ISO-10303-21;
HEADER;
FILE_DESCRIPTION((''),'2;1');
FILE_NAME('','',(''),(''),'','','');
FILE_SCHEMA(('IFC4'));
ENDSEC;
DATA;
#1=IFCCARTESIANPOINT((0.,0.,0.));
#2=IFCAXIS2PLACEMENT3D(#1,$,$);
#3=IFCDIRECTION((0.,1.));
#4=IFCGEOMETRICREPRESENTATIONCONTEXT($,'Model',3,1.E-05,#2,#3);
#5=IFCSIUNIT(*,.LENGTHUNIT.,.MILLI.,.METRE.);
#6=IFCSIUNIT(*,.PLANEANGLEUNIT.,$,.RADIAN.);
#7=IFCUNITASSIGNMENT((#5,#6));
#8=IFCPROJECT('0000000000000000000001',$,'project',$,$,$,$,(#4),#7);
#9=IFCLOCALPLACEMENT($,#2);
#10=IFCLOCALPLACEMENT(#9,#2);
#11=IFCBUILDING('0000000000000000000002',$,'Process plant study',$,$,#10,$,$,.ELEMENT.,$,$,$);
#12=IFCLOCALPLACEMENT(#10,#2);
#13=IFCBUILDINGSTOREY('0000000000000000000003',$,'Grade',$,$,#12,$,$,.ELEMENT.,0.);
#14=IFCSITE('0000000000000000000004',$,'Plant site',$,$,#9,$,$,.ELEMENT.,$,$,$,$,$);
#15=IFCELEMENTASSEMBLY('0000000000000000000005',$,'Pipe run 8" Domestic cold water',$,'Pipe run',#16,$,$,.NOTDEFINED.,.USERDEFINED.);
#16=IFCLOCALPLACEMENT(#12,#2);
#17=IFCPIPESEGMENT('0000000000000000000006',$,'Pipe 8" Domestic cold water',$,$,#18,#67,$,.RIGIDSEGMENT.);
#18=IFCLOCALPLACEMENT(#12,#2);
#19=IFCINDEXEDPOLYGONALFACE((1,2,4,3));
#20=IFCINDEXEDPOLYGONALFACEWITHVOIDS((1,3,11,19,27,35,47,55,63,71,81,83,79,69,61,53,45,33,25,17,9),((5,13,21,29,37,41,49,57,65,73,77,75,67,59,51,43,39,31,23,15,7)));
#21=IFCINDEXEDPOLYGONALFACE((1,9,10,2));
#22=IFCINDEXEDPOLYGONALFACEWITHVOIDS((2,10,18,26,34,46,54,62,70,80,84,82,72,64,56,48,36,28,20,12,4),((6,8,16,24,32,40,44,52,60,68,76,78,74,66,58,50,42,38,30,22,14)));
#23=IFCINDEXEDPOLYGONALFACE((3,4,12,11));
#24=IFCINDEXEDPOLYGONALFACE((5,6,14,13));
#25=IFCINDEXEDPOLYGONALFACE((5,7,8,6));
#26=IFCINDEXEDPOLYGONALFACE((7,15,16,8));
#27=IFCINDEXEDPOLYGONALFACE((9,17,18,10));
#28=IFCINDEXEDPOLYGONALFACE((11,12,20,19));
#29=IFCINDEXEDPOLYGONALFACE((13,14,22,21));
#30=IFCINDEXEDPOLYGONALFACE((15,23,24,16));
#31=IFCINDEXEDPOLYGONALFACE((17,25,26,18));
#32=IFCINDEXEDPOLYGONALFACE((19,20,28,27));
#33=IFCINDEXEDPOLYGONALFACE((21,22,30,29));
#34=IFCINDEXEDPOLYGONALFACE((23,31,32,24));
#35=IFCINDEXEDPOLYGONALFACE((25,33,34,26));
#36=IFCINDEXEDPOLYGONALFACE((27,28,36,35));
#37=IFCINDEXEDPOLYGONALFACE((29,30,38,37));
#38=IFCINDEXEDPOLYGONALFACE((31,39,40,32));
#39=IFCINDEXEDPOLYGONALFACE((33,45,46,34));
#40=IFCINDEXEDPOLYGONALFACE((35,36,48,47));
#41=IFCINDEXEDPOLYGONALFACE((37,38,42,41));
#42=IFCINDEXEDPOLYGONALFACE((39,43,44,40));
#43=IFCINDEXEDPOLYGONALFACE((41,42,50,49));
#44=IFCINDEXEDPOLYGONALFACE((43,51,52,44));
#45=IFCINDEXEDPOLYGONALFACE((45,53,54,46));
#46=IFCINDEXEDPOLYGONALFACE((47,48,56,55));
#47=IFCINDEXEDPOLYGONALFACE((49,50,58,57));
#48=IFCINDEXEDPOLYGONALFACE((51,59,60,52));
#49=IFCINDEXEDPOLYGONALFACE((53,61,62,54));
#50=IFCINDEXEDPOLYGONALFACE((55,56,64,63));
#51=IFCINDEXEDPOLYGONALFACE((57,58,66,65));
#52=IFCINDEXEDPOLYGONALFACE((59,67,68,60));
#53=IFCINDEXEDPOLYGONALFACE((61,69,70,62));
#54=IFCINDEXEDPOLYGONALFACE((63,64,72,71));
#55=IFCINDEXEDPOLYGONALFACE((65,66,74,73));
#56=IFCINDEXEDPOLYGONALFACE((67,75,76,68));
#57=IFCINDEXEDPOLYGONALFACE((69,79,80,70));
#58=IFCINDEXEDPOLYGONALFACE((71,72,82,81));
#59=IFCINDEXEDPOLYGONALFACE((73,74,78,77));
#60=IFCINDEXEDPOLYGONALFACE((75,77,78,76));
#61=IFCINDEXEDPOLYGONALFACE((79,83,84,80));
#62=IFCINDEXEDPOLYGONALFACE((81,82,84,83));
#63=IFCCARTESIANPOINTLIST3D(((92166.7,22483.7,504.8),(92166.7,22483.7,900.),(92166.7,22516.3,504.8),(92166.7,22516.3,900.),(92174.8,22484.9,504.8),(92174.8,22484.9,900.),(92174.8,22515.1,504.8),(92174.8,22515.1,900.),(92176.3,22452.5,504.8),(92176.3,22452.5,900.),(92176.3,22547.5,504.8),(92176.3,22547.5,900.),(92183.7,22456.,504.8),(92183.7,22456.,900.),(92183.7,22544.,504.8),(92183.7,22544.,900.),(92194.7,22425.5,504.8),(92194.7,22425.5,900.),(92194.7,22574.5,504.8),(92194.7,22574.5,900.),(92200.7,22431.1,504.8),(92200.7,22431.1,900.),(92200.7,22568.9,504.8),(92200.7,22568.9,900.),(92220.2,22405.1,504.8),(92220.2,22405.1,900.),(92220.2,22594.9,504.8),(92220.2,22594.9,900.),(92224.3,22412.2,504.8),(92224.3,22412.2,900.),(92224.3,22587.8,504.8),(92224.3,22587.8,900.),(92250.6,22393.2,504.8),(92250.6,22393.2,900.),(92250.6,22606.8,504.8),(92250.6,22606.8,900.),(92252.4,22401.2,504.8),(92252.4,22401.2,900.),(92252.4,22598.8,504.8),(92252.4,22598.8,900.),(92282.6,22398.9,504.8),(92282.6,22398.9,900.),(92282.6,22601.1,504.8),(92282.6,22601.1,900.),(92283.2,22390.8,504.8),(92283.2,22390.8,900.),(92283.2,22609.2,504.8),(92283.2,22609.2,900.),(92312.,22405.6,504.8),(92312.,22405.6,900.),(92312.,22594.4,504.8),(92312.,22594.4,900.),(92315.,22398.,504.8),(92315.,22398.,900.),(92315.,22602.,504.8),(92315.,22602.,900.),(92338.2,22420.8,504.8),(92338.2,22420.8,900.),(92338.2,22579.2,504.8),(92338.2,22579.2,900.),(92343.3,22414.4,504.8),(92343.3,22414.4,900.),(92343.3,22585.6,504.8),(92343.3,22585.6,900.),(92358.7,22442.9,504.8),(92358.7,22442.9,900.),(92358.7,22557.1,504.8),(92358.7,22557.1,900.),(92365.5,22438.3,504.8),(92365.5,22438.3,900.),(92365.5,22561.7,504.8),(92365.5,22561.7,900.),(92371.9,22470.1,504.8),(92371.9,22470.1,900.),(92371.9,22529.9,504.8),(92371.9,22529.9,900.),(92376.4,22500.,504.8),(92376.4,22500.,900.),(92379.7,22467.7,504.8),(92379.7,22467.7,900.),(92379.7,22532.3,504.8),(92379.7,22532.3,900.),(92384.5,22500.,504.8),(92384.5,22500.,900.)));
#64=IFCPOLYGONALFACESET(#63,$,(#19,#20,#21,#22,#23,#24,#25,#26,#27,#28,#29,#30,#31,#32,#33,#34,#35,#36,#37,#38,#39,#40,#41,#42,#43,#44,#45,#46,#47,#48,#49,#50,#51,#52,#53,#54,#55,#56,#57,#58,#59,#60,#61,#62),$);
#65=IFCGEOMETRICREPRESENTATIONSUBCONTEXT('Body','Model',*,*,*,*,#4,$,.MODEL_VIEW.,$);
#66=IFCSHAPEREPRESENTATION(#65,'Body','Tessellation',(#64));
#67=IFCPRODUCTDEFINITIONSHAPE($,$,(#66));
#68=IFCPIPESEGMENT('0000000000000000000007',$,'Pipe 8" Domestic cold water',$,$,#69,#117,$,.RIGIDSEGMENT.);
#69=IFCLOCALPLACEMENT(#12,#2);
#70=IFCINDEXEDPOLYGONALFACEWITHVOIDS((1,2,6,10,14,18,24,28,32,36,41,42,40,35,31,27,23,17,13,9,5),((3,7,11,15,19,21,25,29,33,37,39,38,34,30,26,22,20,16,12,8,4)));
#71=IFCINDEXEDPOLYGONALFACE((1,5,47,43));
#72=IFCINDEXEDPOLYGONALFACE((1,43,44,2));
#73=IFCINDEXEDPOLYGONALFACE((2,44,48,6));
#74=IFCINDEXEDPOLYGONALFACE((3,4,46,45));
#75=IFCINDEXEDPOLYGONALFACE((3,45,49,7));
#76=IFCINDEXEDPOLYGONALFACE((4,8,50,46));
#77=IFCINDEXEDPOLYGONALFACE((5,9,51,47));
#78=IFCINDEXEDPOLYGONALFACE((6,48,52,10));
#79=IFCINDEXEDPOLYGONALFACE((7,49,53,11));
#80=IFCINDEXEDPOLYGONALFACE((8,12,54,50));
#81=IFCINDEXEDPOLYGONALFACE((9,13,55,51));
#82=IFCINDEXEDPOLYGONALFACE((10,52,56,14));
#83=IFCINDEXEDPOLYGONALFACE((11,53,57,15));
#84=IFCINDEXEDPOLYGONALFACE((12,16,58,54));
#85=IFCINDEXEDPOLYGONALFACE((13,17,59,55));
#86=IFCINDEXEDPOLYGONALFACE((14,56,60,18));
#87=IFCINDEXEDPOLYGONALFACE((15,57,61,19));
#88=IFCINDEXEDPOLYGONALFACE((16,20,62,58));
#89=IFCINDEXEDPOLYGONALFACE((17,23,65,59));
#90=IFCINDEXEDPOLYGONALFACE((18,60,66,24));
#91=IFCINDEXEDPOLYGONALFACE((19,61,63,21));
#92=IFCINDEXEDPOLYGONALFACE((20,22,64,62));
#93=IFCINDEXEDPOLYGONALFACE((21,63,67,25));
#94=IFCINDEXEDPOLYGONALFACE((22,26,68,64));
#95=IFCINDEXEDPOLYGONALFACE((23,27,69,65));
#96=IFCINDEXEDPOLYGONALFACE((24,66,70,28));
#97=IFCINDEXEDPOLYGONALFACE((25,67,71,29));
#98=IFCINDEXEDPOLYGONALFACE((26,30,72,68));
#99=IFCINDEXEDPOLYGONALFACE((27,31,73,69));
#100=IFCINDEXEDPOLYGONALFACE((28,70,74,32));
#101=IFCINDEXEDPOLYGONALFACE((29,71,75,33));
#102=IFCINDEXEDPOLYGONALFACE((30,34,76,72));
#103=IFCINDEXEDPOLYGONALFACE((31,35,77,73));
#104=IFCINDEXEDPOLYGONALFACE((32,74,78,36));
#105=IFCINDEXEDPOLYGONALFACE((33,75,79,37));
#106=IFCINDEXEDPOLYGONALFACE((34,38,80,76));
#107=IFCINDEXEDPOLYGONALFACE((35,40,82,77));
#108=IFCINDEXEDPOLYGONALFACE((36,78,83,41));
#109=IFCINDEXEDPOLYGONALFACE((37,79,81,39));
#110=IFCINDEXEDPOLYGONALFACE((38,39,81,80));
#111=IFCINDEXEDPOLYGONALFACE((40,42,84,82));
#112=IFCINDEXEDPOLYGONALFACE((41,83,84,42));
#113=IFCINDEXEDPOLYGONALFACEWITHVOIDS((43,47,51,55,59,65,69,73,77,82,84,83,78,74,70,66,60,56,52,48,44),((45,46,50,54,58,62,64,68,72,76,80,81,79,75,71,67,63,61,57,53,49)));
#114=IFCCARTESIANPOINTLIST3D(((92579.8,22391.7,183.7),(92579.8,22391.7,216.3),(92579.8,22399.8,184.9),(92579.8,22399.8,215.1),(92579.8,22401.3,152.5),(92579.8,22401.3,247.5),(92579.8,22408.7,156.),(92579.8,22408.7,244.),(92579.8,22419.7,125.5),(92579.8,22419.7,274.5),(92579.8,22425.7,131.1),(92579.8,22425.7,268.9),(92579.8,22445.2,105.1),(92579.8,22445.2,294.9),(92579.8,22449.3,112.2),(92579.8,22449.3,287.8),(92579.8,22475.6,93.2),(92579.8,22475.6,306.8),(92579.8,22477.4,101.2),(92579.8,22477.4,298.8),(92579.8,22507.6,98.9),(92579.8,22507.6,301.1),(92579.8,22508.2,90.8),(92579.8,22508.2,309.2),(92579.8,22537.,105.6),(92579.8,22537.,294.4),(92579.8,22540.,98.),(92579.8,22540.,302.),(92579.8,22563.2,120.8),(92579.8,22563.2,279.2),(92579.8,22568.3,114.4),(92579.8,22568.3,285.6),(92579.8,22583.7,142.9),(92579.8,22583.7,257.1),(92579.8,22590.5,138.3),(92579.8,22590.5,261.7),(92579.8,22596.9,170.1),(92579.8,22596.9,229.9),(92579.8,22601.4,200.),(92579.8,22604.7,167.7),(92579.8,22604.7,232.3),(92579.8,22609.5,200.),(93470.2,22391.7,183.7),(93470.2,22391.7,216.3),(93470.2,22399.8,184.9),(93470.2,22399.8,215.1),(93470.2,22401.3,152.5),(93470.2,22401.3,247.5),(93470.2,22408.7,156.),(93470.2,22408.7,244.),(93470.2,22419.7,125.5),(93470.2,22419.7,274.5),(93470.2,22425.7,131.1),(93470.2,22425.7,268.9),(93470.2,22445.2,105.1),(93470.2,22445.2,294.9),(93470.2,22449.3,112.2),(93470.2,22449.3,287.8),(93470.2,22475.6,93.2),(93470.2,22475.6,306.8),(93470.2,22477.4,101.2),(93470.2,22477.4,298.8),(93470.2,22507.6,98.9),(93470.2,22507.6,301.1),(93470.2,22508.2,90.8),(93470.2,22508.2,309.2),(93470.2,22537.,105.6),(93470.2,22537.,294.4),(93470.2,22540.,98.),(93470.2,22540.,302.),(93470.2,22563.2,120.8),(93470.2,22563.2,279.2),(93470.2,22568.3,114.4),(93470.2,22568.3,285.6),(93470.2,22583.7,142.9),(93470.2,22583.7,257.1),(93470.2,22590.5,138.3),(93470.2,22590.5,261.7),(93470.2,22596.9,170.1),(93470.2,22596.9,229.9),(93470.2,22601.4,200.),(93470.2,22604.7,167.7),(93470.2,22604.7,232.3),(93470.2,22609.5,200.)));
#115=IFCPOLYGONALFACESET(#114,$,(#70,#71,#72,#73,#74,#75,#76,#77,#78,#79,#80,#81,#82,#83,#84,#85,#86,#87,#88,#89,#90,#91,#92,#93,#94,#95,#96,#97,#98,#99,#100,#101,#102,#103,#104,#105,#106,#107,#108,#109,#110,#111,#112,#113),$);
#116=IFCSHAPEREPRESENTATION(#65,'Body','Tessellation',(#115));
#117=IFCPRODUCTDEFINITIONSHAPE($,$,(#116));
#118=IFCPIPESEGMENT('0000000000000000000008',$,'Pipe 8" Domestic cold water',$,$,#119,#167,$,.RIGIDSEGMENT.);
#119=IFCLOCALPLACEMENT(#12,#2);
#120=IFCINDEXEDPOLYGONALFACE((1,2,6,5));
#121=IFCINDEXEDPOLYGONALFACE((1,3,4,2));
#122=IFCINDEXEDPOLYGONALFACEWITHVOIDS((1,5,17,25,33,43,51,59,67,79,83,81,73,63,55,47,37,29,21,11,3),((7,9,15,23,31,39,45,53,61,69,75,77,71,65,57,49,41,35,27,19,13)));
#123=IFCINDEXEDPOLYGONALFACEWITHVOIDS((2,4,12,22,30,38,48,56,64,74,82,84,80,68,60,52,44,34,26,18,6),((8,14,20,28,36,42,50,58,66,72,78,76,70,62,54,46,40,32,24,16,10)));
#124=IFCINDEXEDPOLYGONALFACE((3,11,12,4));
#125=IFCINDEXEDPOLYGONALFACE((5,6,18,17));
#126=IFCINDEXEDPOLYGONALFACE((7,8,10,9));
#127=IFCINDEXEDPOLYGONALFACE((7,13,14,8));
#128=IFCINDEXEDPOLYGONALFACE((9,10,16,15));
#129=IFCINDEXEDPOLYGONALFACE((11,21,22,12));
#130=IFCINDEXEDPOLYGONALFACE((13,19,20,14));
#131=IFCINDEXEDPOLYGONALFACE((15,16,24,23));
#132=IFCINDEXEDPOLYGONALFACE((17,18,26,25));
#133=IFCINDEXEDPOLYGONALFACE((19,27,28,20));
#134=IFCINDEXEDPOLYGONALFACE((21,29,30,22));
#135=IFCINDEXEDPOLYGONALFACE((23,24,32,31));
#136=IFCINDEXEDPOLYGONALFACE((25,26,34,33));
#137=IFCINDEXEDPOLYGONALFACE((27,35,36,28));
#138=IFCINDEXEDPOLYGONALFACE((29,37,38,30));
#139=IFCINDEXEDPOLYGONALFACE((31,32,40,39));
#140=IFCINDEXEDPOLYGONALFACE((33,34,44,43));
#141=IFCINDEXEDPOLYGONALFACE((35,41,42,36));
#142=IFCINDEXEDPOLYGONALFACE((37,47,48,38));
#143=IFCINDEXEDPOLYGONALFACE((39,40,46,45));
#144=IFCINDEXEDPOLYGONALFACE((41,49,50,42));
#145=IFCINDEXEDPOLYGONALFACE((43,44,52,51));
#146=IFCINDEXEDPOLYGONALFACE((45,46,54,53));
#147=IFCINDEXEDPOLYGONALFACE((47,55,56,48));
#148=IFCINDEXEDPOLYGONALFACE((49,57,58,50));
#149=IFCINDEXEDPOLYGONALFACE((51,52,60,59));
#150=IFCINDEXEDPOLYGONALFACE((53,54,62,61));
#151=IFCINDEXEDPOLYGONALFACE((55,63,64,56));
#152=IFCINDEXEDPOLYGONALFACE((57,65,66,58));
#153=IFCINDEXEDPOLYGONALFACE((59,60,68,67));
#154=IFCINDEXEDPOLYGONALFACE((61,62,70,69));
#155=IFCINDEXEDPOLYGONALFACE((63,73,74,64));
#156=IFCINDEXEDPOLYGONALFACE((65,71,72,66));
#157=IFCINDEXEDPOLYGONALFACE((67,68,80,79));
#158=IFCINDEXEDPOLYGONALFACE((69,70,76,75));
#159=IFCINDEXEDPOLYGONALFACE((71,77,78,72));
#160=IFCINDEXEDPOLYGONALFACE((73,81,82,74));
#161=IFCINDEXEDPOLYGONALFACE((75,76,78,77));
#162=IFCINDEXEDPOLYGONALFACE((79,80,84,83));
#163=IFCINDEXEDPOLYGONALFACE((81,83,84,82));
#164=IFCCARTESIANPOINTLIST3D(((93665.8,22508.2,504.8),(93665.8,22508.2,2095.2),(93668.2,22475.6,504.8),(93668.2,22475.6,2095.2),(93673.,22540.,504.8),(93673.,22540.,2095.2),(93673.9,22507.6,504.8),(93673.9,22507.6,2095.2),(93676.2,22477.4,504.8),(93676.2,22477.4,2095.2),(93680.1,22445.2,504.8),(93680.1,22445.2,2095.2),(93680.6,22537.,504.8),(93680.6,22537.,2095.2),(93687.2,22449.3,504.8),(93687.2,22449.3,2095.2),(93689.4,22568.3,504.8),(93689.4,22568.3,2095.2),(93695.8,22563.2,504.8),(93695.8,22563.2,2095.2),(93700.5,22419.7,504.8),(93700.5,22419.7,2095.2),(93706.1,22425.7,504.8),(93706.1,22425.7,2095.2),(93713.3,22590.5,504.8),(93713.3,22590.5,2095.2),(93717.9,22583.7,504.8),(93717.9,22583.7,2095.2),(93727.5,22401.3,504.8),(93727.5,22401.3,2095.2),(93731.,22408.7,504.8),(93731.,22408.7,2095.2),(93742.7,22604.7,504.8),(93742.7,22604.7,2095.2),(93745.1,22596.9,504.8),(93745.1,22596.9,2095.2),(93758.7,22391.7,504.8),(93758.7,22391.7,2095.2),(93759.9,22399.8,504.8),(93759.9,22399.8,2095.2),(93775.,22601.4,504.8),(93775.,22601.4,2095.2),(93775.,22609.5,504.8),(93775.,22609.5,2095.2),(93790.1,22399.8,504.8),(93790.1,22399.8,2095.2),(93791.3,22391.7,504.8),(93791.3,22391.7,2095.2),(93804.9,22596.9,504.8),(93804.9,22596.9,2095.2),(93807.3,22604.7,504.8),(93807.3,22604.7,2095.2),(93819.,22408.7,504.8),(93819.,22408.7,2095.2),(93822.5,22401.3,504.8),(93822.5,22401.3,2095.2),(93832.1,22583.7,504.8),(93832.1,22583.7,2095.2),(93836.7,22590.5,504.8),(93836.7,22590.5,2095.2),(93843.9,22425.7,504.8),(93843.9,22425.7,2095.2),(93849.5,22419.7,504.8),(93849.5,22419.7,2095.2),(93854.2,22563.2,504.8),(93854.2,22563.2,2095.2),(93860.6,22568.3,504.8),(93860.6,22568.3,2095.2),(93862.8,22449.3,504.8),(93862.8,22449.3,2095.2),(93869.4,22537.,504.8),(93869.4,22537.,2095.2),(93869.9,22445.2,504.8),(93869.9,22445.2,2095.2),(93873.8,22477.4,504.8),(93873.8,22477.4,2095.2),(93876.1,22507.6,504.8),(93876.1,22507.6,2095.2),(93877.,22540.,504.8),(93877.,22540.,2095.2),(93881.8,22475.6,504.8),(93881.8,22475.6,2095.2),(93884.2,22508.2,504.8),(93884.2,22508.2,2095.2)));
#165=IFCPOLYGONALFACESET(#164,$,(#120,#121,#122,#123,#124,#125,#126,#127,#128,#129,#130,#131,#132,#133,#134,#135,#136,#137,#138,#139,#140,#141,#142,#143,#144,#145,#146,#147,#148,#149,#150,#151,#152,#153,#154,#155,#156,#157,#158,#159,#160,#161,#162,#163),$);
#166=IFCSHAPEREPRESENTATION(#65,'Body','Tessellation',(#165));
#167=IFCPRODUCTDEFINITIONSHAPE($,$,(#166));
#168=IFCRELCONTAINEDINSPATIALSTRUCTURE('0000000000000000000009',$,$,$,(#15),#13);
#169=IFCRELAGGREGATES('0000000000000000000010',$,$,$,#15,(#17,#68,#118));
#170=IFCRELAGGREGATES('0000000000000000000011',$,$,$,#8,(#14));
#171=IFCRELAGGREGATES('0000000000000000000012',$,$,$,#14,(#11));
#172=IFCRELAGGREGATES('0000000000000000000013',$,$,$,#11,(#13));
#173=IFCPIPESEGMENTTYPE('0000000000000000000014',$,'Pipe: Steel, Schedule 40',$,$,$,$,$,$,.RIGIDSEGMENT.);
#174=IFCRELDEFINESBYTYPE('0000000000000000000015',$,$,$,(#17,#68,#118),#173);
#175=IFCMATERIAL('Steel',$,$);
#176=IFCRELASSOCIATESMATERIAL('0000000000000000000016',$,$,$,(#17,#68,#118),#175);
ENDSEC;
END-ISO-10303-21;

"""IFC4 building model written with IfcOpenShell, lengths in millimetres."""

from ifc_helpers import new_model, si_unit, direction, frame, origin, origin_with_axes, origin_2d, place, context, subcontext, project, spatial, hollow_circle, extrude, material, type_object, element, aggregate, save


model = new_model("IFC4")

# Units and contexts
model_context = context("Model", 3, precision=1e-05, world=origin(), true_north=direction((0.0, 1.0)))
body_context = subcontext(model_context, "Body", "Model", "MODEL_VIEW")
ifc_project = project(units=[si_unit("LENGTHUNIT", "METRE", prefix="MILLI"), si_unit("PLANEANGLEUNIT", "RADIAN")], contexts=[model_context])

# Site, building, storey
site_placement = place(None, origin())
site = spatial("IfcSite", under=ifc_project, at=site_placement, Name="Plant site", CompositionType="ELEMENT")
building_placement = place(site_placement, origin())
building = spatial("IfcBuilding", under=site, at=building_placement, Name="Process plant study", CompositionType="ELEMENT")
storey_placement = place(building_placement, origin())
storey = spatial("IfcBuildingStorey", under=building, at=storey_placement, Name="Grade", CompositionType="ELEMENT", Elevation=0.0)

# Shared definitions
ifc_material = material(Name="Steel")
pipe_segment_type = type_object("IfcPipeSegmentType", Name="Pipe: Steel, Schedule 40", PredefinedType="RIGIDSEGMENT")

# Element assembly, pipe segments
assembly_1_placement = place(storey_placement, origin_with_axes())
assembly_1 = element("IfcElementAssembly", 1, at=assembly_1_placement, inside=storey, Name="Pipe run 8\" Domestic cold water", ObjectType="Pipe run", AssemblyPlace="NOTDEFINED", PredefinedType="USERDEFINED")
pipe_segment_1_placement = place(storey_placement, origin_with_axes())
pipe_segment_1 = element("IfcPipeSegment", 2, at=pipe_segment_1_placement, type_object=pipe_segment_type, material=ifc_material, Name="Pipe 8\" Domestic cold water", PredefinedType="RIGIDSEGMENT", context=body_context, shape_type="SweptSolid", body=[
    extrude(hollow_circle(Radius=109.5, WallThickness=8.2, at=origin_2d()), frame((92275.0, 22500.0, 900.0), z_axis=(0.0, 0.0, -1.0), x_axis=(1.0, 0.0, 0.0)), (0.0, 0.0, 1.0), 395.2),
])
pipe_segment_2_placement = place(storey_placement, origin_with_axes())
pipe_segment_2 = element("IfcPipeSegment", 3, at=pipe_segment_2_placement, type_object=pipe_segment_type, material=ifc_material, Name="Pipe 8\" Domestic cold water", PredefinedType="RIGIDSEGMENT", context=body_context, shape_type="SweptSolid", body=[
    extrude(hollow_circle(Radius=109.5, WallThickness=8.2, at=origin_2d()), frame((92579.8, 22500.0, 200.0), z_axis=(1.0, 0.0, 0.0), x_axis=(0.0, 1.0, 0.0)), (0.0, 0.0, 1.0), 890.4),
])
pipe_segment_3_placement = place(storey_placement, origin_with_axes())
pipe_segment_3 = element("IfcPipeSegment", 4, at=pipe_segment_3_placement, type_object=pipe_segment_type, material=ifc_material, Name="Pipe 8\" Domestic cold water", PredefinedType="RIGIDSEGMENT", context=body_context, shape_type="SweptSolid", body=[
    extrude(hollow_circle(Radius=109.5, WallThickness=8.2, at=origin_2d()), frame((93775.0, 22500.0, 504.8), z_axis=(0.0, 0.0, 1.0), x_axis=(0.0, 1.0, 0.0)), (0.0, 0.0, 1.0), 1590.4),
])

aggregate(assembly_1, [pipe_segment_1, pipe_segment_2, pipe_segment_3])

save(model, "model.ifc")
